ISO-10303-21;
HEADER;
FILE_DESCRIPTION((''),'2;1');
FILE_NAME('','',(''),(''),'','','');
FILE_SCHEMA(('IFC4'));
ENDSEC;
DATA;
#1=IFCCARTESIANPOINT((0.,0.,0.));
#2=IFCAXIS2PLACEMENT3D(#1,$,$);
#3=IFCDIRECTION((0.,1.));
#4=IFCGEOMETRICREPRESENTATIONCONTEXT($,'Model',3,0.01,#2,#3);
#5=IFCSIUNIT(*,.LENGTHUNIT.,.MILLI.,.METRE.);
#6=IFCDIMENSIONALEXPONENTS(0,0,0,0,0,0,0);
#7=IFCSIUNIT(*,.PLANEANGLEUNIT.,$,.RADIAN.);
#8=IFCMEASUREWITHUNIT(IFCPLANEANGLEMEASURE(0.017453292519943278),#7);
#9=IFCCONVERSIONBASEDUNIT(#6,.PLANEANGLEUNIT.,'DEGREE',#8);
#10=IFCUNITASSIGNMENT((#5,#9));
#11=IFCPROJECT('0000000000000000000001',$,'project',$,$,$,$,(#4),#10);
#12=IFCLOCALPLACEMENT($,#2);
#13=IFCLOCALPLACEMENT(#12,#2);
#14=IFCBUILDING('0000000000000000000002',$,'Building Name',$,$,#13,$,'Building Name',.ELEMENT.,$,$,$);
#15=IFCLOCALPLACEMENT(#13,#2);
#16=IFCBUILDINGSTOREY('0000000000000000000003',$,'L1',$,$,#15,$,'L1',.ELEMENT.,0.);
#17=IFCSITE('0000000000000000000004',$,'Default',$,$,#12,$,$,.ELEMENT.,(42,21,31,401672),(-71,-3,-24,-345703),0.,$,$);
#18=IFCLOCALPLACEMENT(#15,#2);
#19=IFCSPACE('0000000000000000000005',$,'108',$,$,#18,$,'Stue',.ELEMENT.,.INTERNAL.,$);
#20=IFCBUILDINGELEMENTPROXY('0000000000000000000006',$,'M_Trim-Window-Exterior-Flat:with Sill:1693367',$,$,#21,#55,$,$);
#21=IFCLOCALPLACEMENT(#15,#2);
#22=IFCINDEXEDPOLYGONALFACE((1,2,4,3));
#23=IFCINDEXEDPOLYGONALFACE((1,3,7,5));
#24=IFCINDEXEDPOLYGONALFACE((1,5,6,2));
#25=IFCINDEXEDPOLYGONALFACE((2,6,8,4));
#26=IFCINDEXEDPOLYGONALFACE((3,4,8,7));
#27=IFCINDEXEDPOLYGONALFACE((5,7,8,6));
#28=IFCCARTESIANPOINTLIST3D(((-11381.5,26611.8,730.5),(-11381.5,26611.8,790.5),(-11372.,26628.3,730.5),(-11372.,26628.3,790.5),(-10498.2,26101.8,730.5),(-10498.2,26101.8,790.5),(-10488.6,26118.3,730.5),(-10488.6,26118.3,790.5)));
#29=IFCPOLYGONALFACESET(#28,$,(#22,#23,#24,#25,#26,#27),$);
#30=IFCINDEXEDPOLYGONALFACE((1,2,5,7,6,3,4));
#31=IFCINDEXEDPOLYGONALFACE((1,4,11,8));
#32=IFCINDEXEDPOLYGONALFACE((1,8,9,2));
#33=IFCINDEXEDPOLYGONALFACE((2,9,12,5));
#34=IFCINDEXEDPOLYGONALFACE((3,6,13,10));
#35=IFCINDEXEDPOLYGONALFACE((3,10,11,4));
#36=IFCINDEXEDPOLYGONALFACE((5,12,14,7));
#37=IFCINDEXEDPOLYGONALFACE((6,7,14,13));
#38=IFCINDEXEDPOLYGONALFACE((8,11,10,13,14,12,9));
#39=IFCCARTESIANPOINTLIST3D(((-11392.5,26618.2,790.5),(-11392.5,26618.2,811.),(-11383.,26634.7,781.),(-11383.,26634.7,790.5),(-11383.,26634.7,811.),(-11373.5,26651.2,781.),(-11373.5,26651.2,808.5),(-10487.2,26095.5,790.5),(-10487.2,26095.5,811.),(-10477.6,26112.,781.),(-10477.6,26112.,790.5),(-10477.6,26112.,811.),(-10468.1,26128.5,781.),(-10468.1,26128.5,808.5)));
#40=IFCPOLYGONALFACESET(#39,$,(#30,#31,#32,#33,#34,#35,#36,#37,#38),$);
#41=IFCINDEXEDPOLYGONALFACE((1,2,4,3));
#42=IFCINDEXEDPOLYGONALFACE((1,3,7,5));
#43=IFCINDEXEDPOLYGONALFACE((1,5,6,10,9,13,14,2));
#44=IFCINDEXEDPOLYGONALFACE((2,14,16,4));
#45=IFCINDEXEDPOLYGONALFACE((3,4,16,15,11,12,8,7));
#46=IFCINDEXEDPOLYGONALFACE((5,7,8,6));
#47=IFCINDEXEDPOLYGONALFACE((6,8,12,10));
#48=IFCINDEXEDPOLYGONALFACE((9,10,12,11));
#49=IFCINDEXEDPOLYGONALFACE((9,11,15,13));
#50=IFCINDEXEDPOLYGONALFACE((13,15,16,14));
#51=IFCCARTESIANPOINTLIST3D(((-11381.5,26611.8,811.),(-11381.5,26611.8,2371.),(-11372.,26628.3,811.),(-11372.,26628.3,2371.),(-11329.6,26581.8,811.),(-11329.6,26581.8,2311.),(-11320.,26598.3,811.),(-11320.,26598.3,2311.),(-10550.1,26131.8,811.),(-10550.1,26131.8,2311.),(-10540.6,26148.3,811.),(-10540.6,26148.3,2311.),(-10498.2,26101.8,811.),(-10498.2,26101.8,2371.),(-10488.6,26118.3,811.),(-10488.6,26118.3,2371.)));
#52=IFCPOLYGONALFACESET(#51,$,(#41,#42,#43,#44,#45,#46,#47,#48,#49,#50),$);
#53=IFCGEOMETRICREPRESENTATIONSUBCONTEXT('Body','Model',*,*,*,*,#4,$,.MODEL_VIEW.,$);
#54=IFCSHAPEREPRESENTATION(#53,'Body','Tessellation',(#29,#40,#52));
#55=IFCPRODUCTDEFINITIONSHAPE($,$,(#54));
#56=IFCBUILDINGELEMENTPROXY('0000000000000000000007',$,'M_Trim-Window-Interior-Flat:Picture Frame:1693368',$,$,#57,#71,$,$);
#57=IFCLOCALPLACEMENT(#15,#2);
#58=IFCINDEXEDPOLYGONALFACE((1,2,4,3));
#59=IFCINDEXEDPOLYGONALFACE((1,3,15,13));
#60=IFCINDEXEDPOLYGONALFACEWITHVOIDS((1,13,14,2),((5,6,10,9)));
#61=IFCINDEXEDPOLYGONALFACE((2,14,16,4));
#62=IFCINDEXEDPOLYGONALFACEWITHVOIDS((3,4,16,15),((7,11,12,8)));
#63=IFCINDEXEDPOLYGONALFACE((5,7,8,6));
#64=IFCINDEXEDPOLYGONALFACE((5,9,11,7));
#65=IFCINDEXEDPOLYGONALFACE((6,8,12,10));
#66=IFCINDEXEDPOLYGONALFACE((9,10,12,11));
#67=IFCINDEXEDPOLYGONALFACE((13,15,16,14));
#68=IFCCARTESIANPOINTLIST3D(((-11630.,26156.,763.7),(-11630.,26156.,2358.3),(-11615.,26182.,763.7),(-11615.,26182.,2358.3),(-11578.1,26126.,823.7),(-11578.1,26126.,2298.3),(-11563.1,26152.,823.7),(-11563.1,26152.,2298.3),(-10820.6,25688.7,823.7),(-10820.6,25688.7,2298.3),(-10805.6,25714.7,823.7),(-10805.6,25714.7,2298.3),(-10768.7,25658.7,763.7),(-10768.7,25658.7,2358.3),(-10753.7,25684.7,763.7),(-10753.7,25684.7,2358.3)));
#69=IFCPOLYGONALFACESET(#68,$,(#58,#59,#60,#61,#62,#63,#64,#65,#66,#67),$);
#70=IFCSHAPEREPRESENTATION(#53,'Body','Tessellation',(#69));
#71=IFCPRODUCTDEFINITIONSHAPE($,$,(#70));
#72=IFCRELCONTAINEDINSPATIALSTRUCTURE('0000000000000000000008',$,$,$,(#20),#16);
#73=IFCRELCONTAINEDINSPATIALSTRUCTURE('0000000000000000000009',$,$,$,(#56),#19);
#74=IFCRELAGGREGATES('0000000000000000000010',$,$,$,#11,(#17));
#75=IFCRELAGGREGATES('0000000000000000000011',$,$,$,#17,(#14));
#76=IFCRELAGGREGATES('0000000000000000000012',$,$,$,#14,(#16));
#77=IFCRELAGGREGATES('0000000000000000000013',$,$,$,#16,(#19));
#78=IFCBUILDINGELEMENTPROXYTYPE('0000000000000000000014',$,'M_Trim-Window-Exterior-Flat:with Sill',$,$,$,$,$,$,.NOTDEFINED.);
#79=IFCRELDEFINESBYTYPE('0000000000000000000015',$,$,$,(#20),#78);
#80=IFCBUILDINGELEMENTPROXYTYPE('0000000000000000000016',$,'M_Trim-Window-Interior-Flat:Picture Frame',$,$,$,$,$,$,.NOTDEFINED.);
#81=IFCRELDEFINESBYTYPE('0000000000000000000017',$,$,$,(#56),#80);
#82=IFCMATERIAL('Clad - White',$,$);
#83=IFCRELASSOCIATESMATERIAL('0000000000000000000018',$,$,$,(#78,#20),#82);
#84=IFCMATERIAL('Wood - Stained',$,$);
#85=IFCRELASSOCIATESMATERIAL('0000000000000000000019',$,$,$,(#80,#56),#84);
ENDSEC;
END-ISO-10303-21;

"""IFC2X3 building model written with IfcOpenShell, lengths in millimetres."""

from ifc_helpers import new_model, entity, si_unit, converted_unit, direction, frame, frame_2d, origin, place, context, subcontext, project, spatial, polyline, rectangle, outline, extrude, source, transform, mapped, material, type_object, type_shapes, element, save


model = new_model("IFC2X3")

# Units and contexts
model_context = context("Model", 3, precision=0.01, world=origin(), true_north=direction((0.0, 1.0)))
body_context = subcontext(model_context, "Body", "Model", "MODEL_VIEW")
ifc_project = project(units=[si_unit("LENGTHUNIT", "METRE", prefix="MILLI"), converted_unit("PLANEANGLEUNIT", "DEGREE", entity("IfcPlaneAngleMeasure", 0.017453292519943278), si_unit("PLANEANGLEUNIT", "RADIAN"), dimensions=[0, 0, 0, 0, 0, 0, 0])], contexts=[model_context])

# Site, building, storey
site_placement = place(None, origin())
site = spatial("IfcSite", under=ifc_project, at=site_placement, Name="Default", CompositionType="ELEMENT", RefLatitude=(42, 21, 31, 401672), RefLongitude=(-71, -3, -24, -345703), RefElevation=0.0)
building_placement = place(site_placement, origin())
building = spatial("IfcBuilding", under=site, at=building_placement, Name="Building Name", LongName="Building Name", CompositionType="ELEMENT")
storey_placement = place(building_placement, origin())
storey = spatial("IfcBuildingStorey", under=building, at=storey_placement, Name="L1", LongName="L1", CompositionType="ELEMENT", Elevation=0.0)

# Shared definitions
ifc_material_1 = material(Name="Wood - Stained")

# Shared definitions
ifc_material_2 = material(Name="Clad - White")

# Shared definitions
space_placement = place(storey_placement, origin())
space = spatial("IfcSpace", under=storey, at=space_placement, Name="108", LongName="Stue", CompositionType="ELEMENT", InteriorOrExteriorSpace="INTERNAL")

# Building element proxies
building_element_proxy_type_1 = type_object("IfcBuildingElementProxyType", Name="M_Trim-Window-Exterior-Flat:with Sill", PredefinedType="NOTDEFINED", material=ifc_material_2)
shared_shape_1 = source(origin(), body_context, "Body", "SweptSolid", [
    extrude(rectangle(XDim=1020.0, YDim=60.0, at=frame_2d((0.0, 0.0), x_axis=(1.0, 0.0))), frame((0.0, -1550.4, 0.0), z_axis=(0.0, 0.0, 1.0), x_axis=(-1.0, 0.0, 0.0)), (0.0, 0.0, 1.0), 19.0),
    extrude(outline(polyline([(-19.0, -15.2), (0.0, -15.2), (0.0, -5.7), (19.0, -5.7), (19.0, 14.8), (0.0, 14.8), (-19.0, 12.3), (-19.0, -15.2)])), frame((-522.7, -1514.8, 19.0), z_axis=(1.0, 0.0, 0.0), x_axis=(0.0, 0.0, -1.0)), (0.0, 0.0, 1.0), 1045.4),
    extrude(outline(polyline([(-795.0, -510.0), (765.0, -510.0), (765.0, -450.0), (-735.0, -450.0), (-735.0, 450.0), (765.0, 450.0), (765.0, 510.0), (-795.0, 510.0), (-795.0, -510.0)])), frame((0.0, -735.0, 0.0), z_axis=(0.0, 0.0, 1.0), x_axis=(0.0, -1.0, 0.0)), (0.0, 0.0, 1.0), 19.0),
])
type_shapes(building_element_proxy_type_1, [shared_shape_1])
proxy_1_placement = place(storey_placement, frame((-10939.8, 26356.8, 2311.0), z_axis=(0.5, 0.866025, 0.0), x_axis=(-0.866025, 0.5, 0.0)))
element("IfcBuildingElementProxy", 1, at=proxy_1_placement, inside=storey, type_object=building_element_proxy_type_1, material=ifc_material_2, Name="M_Trim-Window-Exterior-Flat:with Sill:1693367", context=body_context, shape_type="MappedRepresentation", body=[
    mapped(shared_shape_1, transform((0.0, 0.0, 0.0), scale=1.0)),
])
building_element_proxy_type_2 = type_object("IfcBuildingElementProxyType", Name="M_Trim-Window-Interior-Flat:Picture Frame", PredefinedType="NOTDEFINED", material=ifc_material_1)
shared_shape_2 = source(origin(), body_context, "Body", "SweptSolid", [
    extrude(outline(polyline([(-497.3, -797.3), (497.3, -797.3), (497.3, 797.3), (-497.3, 797.3), (-497.3, -797.3)]), holes=[polyline([(-437.3, -737.3), (-437.3, 737.3), (437.3, 737.3), (437.3, -737.3), (-437.3, -737.3)])]), frame((0.0, -750.0, 0.0), z_axis=(0.0, 0.0, 1.0), x_axis=(-1.0, 0.0, 0.0)), (0.0, 0.0, 1.0), 30.0),
])
type_shapes(building_element_proxy_type_2, [shared_shape_2])
proxy_2_placement = place(space_placement, frame((-11184.3, 25933.4, 2311.0), z_axis=(-0.5, -0.866025, 0.0), x_axis=(0.866025, -0.5, 0.0)))
element("IfcBuildingElementProxy", 2, at=proxy_2_placement, inside=space, type_object=building_element_proxy_type_2, material=ifc_material_1, Name="M_Trim-Window-Interior-Flat:Picture Frame:1693368", context=body_context, shape_type="MappedRepresentation", body=[
    mapped(shared_shape_2, transform((0.0, 0.0, 0.0), scale=1.0)),
])

save(model, "model.ifc")
